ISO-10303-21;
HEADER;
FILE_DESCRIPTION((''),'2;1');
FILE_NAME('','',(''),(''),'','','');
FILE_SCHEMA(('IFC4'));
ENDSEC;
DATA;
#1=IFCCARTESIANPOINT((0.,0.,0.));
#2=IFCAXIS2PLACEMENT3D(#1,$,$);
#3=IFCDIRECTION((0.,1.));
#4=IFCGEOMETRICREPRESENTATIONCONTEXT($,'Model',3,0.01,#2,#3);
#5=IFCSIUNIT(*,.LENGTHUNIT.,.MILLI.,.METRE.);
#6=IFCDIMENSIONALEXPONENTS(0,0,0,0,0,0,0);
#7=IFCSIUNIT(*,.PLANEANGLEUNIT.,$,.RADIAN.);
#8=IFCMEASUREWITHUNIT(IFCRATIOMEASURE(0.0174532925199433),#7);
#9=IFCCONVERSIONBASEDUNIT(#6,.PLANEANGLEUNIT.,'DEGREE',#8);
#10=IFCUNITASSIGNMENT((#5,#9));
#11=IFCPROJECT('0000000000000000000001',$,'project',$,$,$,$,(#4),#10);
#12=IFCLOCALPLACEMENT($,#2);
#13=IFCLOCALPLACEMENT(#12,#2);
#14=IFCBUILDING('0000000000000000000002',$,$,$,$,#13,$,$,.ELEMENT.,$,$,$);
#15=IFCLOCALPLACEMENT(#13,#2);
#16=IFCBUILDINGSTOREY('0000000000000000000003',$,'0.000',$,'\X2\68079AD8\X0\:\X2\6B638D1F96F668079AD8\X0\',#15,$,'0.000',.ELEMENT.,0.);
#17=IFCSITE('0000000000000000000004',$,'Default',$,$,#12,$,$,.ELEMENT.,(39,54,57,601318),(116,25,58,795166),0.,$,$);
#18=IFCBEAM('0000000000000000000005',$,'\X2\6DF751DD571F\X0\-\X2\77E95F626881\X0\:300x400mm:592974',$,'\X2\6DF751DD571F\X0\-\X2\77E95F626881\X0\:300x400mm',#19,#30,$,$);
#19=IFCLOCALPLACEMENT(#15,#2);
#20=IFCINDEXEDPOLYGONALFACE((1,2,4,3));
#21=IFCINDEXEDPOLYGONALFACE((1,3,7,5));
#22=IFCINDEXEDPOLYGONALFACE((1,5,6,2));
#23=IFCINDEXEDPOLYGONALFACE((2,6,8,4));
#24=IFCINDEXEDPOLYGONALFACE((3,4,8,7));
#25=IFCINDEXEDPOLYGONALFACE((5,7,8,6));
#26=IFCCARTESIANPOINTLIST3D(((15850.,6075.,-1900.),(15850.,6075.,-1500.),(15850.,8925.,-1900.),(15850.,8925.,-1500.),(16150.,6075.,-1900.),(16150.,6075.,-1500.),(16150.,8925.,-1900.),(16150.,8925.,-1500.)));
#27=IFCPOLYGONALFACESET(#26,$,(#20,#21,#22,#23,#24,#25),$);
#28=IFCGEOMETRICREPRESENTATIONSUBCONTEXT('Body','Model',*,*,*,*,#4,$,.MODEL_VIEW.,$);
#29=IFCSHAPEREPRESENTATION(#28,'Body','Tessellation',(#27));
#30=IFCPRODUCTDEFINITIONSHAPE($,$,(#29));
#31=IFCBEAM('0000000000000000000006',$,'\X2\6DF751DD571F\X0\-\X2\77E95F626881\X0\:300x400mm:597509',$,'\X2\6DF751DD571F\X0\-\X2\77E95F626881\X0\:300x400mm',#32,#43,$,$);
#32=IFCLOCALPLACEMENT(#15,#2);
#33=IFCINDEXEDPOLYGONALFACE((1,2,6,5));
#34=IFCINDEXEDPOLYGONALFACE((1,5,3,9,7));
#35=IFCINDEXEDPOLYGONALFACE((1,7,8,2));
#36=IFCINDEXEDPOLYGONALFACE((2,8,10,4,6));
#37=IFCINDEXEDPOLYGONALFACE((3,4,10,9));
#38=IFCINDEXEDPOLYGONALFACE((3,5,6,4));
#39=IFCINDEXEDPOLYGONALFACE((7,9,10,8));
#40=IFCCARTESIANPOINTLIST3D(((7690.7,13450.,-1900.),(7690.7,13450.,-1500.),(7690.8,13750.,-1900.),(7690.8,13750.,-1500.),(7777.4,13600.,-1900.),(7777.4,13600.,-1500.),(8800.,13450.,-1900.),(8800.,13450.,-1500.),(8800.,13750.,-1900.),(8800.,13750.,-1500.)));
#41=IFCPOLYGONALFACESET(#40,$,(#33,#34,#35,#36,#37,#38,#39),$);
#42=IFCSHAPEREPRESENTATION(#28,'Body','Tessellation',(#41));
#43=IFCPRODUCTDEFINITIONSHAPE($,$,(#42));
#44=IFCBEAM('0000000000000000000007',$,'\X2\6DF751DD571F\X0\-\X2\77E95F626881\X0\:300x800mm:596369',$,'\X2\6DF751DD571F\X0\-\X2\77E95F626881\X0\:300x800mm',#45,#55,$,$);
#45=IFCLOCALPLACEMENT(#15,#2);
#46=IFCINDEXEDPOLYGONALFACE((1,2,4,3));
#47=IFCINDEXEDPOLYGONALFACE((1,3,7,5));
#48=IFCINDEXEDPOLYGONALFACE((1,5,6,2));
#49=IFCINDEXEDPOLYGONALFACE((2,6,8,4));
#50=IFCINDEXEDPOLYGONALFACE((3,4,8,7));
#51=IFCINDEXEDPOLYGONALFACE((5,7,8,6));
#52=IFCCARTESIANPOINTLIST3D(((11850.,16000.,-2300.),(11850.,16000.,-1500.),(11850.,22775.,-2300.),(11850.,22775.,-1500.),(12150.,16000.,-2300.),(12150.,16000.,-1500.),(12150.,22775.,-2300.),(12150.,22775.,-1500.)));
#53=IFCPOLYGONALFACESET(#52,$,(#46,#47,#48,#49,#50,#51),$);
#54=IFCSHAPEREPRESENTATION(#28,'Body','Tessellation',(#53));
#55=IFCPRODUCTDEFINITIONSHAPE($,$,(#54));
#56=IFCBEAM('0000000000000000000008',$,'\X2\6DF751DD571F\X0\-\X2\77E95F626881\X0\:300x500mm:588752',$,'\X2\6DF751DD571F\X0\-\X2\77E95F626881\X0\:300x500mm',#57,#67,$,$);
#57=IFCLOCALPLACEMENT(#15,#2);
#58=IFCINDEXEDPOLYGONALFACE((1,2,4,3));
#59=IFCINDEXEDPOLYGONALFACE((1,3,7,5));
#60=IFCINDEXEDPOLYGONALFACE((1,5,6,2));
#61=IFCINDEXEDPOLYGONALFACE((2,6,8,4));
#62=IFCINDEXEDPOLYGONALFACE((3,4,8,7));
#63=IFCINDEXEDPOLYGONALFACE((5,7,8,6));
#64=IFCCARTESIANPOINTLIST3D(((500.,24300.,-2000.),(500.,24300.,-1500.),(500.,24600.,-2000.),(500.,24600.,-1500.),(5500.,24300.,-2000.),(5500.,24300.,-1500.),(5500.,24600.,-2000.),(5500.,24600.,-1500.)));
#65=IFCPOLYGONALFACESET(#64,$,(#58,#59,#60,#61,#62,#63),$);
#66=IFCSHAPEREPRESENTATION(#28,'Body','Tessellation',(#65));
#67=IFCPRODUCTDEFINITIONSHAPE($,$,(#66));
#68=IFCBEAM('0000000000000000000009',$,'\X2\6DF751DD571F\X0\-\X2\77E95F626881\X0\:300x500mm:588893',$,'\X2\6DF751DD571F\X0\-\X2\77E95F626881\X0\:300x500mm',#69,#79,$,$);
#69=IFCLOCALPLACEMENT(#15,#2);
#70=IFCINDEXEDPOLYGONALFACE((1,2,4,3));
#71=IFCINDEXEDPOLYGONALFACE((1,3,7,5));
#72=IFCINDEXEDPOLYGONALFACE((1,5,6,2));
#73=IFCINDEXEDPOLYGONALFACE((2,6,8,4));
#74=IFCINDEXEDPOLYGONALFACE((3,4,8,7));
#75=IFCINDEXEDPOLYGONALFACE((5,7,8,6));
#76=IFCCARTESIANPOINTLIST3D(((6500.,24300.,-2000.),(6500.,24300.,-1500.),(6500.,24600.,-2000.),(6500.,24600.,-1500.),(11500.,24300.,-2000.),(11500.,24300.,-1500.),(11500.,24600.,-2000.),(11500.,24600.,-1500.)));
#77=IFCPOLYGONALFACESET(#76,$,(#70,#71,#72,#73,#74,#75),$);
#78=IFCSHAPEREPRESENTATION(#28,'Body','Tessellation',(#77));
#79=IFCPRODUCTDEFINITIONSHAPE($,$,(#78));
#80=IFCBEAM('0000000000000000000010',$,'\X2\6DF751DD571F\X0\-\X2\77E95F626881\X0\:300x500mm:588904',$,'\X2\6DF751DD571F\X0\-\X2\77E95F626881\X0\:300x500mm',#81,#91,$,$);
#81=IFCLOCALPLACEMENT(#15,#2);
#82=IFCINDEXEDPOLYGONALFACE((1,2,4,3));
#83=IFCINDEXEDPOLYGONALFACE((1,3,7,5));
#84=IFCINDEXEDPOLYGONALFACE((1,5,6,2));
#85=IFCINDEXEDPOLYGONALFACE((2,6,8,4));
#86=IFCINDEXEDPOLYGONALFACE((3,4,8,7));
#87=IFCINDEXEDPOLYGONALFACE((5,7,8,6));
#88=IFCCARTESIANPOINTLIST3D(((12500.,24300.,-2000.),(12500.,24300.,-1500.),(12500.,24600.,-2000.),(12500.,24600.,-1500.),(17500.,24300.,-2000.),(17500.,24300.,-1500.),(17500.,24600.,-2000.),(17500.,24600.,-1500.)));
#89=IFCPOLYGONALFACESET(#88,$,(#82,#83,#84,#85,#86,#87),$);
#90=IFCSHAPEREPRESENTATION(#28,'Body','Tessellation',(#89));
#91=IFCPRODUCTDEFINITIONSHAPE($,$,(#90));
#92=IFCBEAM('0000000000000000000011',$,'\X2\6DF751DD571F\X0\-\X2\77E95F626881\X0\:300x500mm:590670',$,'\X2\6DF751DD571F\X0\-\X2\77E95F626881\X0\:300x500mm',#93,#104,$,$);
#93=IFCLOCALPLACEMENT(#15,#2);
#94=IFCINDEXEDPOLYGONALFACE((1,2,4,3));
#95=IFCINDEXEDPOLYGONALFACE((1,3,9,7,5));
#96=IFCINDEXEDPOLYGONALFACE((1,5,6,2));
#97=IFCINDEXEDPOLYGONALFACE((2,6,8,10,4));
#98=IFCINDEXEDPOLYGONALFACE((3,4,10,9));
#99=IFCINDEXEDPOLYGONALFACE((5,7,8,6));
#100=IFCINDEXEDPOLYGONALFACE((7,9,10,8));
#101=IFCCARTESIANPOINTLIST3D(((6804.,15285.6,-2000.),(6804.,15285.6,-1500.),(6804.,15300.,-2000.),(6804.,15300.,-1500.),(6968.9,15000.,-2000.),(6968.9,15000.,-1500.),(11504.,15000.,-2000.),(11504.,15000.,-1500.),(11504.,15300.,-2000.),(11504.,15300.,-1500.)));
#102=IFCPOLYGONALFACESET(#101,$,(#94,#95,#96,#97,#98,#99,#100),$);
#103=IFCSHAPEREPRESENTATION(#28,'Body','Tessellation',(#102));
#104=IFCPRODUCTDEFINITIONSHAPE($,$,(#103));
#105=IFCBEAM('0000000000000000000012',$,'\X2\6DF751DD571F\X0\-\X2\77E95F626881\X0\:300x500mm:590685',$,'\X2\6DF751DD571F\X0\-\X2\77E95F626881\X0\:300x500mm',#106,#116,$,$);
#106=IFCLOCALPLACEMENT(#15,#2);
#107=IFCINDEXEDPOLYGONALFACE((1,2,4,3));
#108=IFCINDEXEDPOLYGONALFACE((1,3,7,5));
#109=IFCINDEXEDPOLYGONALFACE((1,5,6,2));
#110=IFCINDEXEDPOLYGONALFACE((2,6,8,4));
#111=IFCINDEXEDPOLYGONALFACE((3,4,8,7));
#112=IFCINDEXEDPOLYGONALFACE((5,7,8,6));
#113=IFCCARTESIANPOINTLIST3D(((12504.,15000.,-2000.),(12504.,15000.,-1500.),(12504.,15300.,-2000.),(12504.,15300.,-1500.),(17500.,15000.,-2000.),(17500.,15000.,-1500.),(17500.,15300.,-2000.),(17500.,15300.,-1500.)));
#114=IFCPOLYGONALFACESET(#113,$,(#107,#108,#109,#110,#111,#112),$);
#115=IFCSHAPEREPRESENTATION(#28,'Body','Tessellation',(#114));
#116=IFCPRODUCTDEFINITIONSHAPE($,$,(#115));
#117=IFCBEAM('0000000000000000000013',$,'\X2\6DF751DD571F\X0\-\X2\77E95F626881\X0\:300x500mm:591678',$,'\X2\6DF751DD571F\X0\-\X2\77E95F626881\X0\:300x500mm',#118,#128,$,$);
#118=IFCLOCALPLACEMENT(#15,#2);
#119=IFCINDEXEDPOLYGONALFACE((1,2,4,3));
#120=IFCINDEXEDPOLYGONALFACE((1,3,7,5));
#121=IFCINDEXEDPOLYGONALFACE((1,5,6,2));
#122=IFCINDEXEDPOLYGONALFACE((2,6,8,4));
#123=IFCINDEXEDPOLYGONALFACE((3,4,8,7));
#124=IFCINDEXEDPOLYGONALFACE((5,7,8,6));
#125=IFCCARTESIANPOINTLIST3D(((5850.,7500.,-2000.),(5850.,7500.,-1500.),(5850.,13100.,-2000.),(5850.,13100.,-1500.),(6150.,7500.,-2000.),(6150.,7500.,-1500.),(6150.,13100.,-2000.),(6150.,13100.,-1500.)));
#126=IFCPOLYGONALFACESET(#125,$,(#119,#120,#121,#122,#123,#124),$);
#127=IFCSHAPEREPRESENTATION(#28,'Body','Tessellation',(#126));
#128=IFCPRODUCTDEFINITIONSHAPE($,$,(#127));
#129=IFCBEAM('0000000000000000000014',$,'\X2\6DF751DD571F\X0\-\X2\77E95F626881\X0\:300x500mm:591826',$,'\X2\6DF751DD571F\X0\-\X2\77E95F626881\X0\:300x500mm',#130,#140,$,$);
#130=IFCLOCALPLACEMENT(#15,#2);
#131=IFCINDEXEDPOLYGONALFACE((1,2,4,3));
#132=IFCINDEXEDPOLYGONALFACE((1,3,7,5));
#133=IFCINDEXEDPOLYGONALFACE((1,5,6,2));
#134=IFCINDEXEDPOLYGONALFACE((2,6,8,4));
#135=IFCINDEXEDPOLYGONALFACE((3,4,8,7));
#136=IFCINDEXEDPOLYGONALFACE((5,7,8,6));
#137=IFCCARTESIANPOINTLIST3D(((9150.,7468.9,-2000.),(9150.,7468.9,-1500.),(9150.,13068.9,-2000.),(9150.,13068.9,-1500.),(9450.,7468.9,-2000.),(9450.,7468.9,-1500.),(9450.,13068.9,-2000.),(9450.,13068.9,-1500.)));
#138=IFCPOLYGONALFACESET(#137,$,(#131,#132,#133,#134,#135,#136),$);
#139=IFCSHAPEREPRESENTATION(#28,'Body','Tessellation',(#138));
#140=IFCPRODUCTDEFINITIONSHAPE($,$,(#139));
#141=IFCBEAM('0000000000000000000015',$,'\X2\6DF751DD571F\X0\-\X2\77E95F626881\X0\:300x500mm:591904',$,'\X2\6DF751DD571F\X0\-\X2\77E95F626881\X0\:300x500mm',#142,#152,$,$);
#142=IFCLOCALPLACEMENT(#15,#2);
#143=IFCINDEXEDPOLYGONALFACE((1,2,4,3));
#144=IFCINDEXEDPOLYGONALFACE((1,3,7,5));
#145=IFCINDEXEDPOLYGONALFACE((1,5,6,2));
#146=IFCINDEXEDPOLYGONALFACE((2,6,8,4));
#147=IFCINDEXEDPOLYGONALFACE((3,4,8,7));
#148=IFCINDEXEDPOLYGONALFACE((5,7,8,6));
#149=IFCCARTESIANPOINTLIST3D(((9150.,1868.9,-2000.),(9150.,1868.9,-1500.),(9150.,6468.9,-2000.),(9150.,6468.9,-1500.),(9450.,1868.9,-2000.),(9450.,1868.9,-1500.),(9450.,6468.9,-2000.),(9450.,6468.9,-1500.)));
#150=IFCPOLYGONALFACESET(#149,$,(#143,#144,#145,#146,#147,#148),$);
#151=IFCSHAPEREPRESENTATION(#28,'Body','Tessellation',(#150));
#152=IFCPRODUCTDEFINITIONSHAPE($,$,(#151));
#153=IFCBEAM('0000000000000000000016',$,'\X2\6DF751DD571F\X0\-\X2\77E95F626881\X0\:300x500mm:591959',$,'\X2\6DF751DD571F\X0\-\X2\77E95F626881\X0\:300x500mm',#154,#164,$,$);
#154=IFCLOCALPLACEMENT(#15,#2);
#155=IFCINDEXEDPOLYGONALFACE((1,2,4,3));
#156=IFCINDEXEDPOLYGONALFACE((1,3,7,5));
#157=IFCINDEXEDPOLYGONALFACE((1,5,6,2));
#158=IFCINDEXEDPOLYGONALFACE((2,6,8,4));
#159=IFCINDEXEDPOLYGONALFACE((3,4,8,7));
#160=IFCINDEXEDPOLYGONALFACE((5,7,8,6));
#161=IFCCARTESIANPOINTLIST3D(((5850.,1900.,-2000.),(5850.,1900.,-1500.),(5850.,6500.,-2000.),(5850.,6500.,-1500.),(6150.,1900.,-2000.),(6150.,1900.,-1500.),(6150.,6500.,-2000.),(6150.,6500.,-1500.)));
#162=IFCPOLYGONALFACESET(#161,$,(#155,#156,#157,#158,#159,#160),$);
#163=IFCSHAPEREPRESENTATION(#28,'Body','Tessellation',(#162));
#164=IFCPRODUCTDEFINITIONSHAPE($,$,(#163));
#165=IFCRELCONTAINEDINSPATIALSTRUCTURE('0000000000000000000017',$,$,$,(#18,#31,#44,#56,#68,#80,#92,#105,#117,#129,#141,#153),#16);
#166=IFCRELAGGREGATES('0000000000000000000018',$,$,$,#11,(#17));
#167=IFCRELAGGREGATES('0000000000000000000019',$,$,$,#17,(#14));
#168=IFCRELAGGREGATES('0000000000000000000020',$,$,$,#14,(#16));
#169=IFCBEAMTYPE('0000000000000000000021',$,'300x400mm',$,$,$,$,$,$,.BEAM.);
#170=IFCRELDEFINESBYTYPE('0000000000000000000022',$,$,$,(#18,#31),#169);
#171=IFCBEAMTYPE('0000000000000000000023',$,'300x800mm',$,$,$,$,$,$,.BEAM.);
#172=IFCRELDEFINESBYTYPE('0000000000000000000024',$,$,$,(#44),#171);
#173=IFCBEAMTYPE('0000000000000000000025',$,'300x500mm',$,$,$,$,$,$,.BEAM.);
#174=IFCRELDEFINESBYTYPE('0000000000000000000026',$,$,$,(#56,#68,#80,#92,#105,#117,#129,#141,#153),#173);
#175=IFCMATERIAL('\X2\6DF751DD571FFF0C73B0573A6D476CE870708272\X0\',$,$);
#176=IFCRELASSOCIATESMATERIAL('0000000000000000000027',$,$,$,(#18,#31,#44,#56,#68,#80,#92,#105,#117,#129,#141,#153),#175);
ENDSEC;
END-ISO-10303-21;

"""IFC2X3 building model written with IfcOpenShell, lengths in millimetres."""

from ifc_helpers import new_model, entity, si_unit, converted_unit, direction, frame, frame_2d, origin, place, context, subcontext, project, spatial, polyline, rectangle, extrude, clip, halfspace, bounded_halfspace, material, type_object, element, save


model = new_model("IFC2X3")

# Units and contexts
model_context = context("Model", 3, precision=0.01, world=origin(), true_north=direction((0.0, 1.0)))
body_context = subcontext(model_context, "Body", "Model", "MODEL_VIEW")
ifc_project = project(units=[si_unit("LENGTHUNIT", "METRE", prefix="MILLI"), converted_unit("PLANEANGLEUNIT", "DEGREE", entity("IfcRatioMeasure", 0.0174532925199433), si_unit("PLANEANGLEUNIT", "RADIAN"), dimensions=[0, 0, 0, 0, 0, 0, 0])], contexts=[model_context])

# Site, building, storey
site_placement = place(None, origin())
site = spatial("IfcSite", under=ifc_project, at=site_placement, Name="Default", CompositionType="ELEMENT", RefLatitude=(39, 54, 57, 601318), RefLongitude=(116, 25, 58, 795166), RefElevation=0.0)
building_placement = place(site_placement, origin())
building = spatial("IfcBuilding", under=site, at=building_placement, CompositionType="ELEMENT")
storey_placement = place(building_placement, origin())
storey = spatial("IfcBuildingStorey", under=building, at=storey_placement, Name="0.000", ObjectType="标高:正负零标高", LongName="0.000", CompositionType="ELEMENT", Elevation=0.0)

# Shared definitions
ifc_material = material(Name="混凝土，现场浇注灰色")

# Beams
beam_type_1 = type_object("IfcBeamType", Name="300x400mm", PredefinedType="BEAM")
for number, where, z_axis, x_axis, name in (
    (1, (16000.0, 8925.0, -1500.0), (0.0, 0.0, 1.0), (0.0, -1.0, 0.0), "混凝土-矩形梁:300x400mm:592974"),
):
    element("IfcBeam", number, at=place(storey_placement, frame(where, z_axis=z_axis, x_axis=x_axis)), inside=storey, type_object=beam_type_1, material=ifc_material, Name=name, ObjectType="混凝土-矩形梁:300x400mm", context=body_context, shape_type="SweptSolid", body=[
        extrude(rectangle(XDim=400.0, YDim=300.0, at=frame_2d((0.0, 0.0), x_axis=(1.0, 0.0))), frame((0.0, 0.0, -200.0), z_axis=(1.0, 0.0, 0.0), x_axis=(0.0, 0.0, -1.0)), (0.0, 0.0, 1.0), 2850.0),
    ])
beam_1_placement = place(storey_placement, frame((8800.7, 13600.0, -1500.0), z_axis=(0.0, 0.0, 1.0), x_axis=(-1.0, 0.0, 0.0)))
element("IfcBeam", 2, at=beam_1_placement, inside=storey, type_object=beam_type_1, material=ifc_material, Name="混凝土-矩形梁:300x400mm:597509", ObjectType="混凝土-矩形梁:300x400mm", context=body_context, shape_type="Clipping", body=[
    clip(clip(extrude(rectangle(XDim=400.0, YDim=300.0, at=frame_2d((0.0, 0.0), x_axis=(1.0, 0.000014))), frame((0.7, 0.0, -200.0), z_axis=(1.0, 0.0, 0.0), x_axis=(0.0, 0.0, -1.0)), (0.0, 0.0, 1.0), 1109.3), bounded_halfspace(frame((1312.1, 500.0, 0.0), z_axis=(0.866025, -0.5, 0.0), x_axis=(0.0, 0.0, -1.0)), False, frame((0.7, 0.0, -200.0), z_axis=(1.0, 0.0, 0.0), x_axis=(0.0, 0.0, -1.0)), polyline([(-200.0, 0.0), (200.0, 0.0), (200.0, 150.0), (-200.0, 150.0), (-200.0, 0.0)]))), bounded_halfspace(frame((1023.4, 0.0, 0.0), z_axis=(0.865977, 0.500083, 0.0), x_axis=(0.0, 0.0, -1.0)), False, frame((0.7, 0.0, -200.0), z_axis=(1.0, 0.0, 0.0), x_axis=(0.0, 0.0, -1.0)), polyline([(200.0, 0.0), (-200.0, 0.0), (-200.0, -150.0), (200.0, -150.0), (200.0, 0.0)]))),
])
beam_type_2 = type_object("IfcBeamType", Name="300x800mm", PredefinedType="BEAM")
beam_2_placement = place(storey_placement, frame((12000.0, 22775.0, -1500.0), z_axis=(0.0, 0.0, 1.0), x_axis=(0.0, -1.0, 0.0)))
element("IfcBeam", 3, at=beam_2_placement, inside=storey, type_object=beam_type_2, material=ifc_material, Name="混凝土-矩形梁:300x800mm:596369", ObjectType="混凝土-矩形梁:300x800mm", context=body_context, shape_type="SweptSolid", body=[
    extrude(rectangle(XDim=800.0, YDim=300.0, at=frame_2d((0.0, 0.0), x_axis=(1.0, 0.0))), frame((0.0, 0.0, -400.0), z_axis=(1.0, 0.0, 0.0), x_axis=(0.0, 0.0, -1.0)), (0.0, 0.0, 1.0), 6775.0),
])
beam_type_3 = type_object("IfcBeamType", Name="300x500mm", PredefinedType="BEAM")
for number, where, name in (
    (4, (500.0, 24450.0, -1500.0), "混凝土-矩形梁:300x500mm:588752"),
    (5, (6500.0, 24450.0, -1500.0), "混凝土-矩形梁:300x500mm:588893"),
    (6, (12500.0, 24450.0, -1500.0), "混凝土-矩形梁:300x500mm:588904"),
):
    element("IfcBeam", number, at=place(storey_placement, frame(where)), inside=storey, type_object=beam_type_3, material=ifc_material, Name=name, ObjectType="混凝土-矩形梁:300x500mm", context=body_context, shape_type="SweptSolid", body=[
        extrude(rectangle(XDim=500.0, YDim=300.0, at=frame_2d((0.0, 0.0), x_axis=(1.0, 0.0))), frame((0.0, 0.0, -250.0), z_axis=(1.0, 0.0, 0.0), x_axis=(0.0, 0.0, -1.0)), (0.0, 0.0, 1.0), 5000.0),
    ])
beam_3_placement = place(storey_placement, frame((6804.0, 15150.0, -1500.0)))
element("IfcBeam", 7, at=beam_3_placement, inside=storey, type_object=beam_type_3, material=ifc_material, Name="混凝土-矩形梁:300x500mm:590670", ObjectType="混凝土-矩形梁:300x500mm", context=body_context, shape_type="Clipping", body=[
    clip(extrude(rectangle(XDim=500.0, YDim=300.0, at=frame_2d((0.0, 0.0), x_axis=(1.0, 0.0))), frame((0.0, 0.0, -250.0), z_axis=(1.0, 0.0, 0.0), x_axis=(0.0, 0.0, -1.0)), (0.0, 0.0, 1.0), 4700.0), halfspace(frame((973.4, -1550.0, 0.0), z_axis=(-0.865977, -0.500083, 0.0), x_axis=(0.0, 0.0, -1.0)), False)),
])
beam_4_placement = place(storey_placement, frame((12504.0, 15150.0, -1500.0)))
element("IfcBeam", 8, at=beam_4_placement, inside=storey, type_object=beam_type_3, material=ifc_material, Name="混凝土-矩形梁:300x500mm:590685", ObjectType="混凝土-矩形梁:300x500mm", context=body_context, shape_type="SweptSolid", body=[
    extrude(rectangle(XDim=500.0, YDim=300.0, at=frame_2d((0.0, 0.0), x_axis=(1.0, 0.0))), frame((0.0, 0.0, -250.0), z_axis=(1.0, 0.0, 0.0), x_axis=(0.0, 0.0, -1.0)), (0.0, 0.0, 1.0), 4996.0),
])
beam_5_placement = place(storey_placement, frame((6000.0, 13100.0, -1500.0), z_axis=(0.0, 0.0, 1.0), x_axis=(0.0, -1.0, 0.0)))
element("IfcBeam", 9, at=beam_5_placement, inside=storey, type_object=beam_type_3, material=ifc_material, Name="混凝土-矩形梁:300x500mm:591678", ObjectType="混凝土-矩形梁:300x500mm", context=body_context, shape_type="SweptSolid", body=[
    extrude(rectangle(XDim=500.0, YDim=300.0, at=frame_2d((0.0, 0.0), x_axis=(1.0, 0.0))), frame((0.0, 0.0, -250.0), z_axis=(1.0, 0.0, 0.0), x_axis=(0.0, 0.0, -1.0)), (0.0, 0.0, 1.0), 5600.0),
])
beam_6_placement = place(storey_placement, frame((9300.0, 13100.0, -1500.0), z_axis=(0.0, 0.0, 1.0), x_axis=(0.0, -1.0, 0.0)))
element("IfcBeam", 10, at=beam_6_placement, inside=storey, type_object=beam_type_3, material=ifc_material, Name="混凝土-矩形梁:300x500mm:591826", ObjectType="混凝土-矩形梁:300x500mm", context=body_context, shape_type="SweptSolid", body=[
    extrude(rectangle(XDim=500.0, YDim=300.0, at=frame_2d((0.0, 0.0), x_axis=(1.0, 0.0))), frame((31.1, 0.0, -250.0), z_axis=(1.0, 0.0, 0.0), x_axis=(0.0, 0.0, -1.0)), (0.0, 0.0, 1.0), 5600.0),
])
beam_7_placement = place(storey_placement, frame((9300.0, 6500.0, -1500.0), z_axis=(0.0, 0.0, 1.0), x_axis=(0.0, -1.0, 0.0)))
element("IfcBeam", 11, at=beam_7_placement, inside=storey, type_object=beam_type_3, material=ifc_material, Name="混凝土-矩形梁:300x500mm:591904", ObjectType="混凝土-矩形梁:300x500mm", context=body_context, shape_type="SweptSolid", body=[
    extrude(rectangle(XDim=500.0, YDim=300.0, at=frame_2d((0.0, 0.0), x_axis=(1.0, 0.0))), frame((31.1, 0.0, -250.0), z_axis=(1.0, 0.0, 0.0), x_axis=(0.0, 0.0, -1.0)), (0.0, 0.0, 1.0), 4600.0),
])
beam_8_placement = place(storey_placement, frame((6000.0, 6500.0, -1500.0), z_axis=(0.0, 0.0, 1.0), x_axis=(0.0, -1.0, 0.0)))
element("IfcBeam", 12, at=beam_8_placement, inside=storey, type_object=beam_type_3, material=ifc_material, Name="混凝土-矩形梁:300x500mm:591959", ObjectType="混凝土-矩形梁:300x500mm", context=body_context, shape_type="SweptSolid", body=[
    extrude(rectangle(XDim=500.0, YDim=300.0, at=frame_2d((0.0, 0.0), x_axis=(1.0, 0.0))), frame((0.0, 0.0, -250.0), z_axis=(1.0, 0.0, 0.0), x_axis=(0.0, 0.0, -1.0)), (0.0, 0.0, 1.0), 4600.0),
])

save(model, "model.ifc")
